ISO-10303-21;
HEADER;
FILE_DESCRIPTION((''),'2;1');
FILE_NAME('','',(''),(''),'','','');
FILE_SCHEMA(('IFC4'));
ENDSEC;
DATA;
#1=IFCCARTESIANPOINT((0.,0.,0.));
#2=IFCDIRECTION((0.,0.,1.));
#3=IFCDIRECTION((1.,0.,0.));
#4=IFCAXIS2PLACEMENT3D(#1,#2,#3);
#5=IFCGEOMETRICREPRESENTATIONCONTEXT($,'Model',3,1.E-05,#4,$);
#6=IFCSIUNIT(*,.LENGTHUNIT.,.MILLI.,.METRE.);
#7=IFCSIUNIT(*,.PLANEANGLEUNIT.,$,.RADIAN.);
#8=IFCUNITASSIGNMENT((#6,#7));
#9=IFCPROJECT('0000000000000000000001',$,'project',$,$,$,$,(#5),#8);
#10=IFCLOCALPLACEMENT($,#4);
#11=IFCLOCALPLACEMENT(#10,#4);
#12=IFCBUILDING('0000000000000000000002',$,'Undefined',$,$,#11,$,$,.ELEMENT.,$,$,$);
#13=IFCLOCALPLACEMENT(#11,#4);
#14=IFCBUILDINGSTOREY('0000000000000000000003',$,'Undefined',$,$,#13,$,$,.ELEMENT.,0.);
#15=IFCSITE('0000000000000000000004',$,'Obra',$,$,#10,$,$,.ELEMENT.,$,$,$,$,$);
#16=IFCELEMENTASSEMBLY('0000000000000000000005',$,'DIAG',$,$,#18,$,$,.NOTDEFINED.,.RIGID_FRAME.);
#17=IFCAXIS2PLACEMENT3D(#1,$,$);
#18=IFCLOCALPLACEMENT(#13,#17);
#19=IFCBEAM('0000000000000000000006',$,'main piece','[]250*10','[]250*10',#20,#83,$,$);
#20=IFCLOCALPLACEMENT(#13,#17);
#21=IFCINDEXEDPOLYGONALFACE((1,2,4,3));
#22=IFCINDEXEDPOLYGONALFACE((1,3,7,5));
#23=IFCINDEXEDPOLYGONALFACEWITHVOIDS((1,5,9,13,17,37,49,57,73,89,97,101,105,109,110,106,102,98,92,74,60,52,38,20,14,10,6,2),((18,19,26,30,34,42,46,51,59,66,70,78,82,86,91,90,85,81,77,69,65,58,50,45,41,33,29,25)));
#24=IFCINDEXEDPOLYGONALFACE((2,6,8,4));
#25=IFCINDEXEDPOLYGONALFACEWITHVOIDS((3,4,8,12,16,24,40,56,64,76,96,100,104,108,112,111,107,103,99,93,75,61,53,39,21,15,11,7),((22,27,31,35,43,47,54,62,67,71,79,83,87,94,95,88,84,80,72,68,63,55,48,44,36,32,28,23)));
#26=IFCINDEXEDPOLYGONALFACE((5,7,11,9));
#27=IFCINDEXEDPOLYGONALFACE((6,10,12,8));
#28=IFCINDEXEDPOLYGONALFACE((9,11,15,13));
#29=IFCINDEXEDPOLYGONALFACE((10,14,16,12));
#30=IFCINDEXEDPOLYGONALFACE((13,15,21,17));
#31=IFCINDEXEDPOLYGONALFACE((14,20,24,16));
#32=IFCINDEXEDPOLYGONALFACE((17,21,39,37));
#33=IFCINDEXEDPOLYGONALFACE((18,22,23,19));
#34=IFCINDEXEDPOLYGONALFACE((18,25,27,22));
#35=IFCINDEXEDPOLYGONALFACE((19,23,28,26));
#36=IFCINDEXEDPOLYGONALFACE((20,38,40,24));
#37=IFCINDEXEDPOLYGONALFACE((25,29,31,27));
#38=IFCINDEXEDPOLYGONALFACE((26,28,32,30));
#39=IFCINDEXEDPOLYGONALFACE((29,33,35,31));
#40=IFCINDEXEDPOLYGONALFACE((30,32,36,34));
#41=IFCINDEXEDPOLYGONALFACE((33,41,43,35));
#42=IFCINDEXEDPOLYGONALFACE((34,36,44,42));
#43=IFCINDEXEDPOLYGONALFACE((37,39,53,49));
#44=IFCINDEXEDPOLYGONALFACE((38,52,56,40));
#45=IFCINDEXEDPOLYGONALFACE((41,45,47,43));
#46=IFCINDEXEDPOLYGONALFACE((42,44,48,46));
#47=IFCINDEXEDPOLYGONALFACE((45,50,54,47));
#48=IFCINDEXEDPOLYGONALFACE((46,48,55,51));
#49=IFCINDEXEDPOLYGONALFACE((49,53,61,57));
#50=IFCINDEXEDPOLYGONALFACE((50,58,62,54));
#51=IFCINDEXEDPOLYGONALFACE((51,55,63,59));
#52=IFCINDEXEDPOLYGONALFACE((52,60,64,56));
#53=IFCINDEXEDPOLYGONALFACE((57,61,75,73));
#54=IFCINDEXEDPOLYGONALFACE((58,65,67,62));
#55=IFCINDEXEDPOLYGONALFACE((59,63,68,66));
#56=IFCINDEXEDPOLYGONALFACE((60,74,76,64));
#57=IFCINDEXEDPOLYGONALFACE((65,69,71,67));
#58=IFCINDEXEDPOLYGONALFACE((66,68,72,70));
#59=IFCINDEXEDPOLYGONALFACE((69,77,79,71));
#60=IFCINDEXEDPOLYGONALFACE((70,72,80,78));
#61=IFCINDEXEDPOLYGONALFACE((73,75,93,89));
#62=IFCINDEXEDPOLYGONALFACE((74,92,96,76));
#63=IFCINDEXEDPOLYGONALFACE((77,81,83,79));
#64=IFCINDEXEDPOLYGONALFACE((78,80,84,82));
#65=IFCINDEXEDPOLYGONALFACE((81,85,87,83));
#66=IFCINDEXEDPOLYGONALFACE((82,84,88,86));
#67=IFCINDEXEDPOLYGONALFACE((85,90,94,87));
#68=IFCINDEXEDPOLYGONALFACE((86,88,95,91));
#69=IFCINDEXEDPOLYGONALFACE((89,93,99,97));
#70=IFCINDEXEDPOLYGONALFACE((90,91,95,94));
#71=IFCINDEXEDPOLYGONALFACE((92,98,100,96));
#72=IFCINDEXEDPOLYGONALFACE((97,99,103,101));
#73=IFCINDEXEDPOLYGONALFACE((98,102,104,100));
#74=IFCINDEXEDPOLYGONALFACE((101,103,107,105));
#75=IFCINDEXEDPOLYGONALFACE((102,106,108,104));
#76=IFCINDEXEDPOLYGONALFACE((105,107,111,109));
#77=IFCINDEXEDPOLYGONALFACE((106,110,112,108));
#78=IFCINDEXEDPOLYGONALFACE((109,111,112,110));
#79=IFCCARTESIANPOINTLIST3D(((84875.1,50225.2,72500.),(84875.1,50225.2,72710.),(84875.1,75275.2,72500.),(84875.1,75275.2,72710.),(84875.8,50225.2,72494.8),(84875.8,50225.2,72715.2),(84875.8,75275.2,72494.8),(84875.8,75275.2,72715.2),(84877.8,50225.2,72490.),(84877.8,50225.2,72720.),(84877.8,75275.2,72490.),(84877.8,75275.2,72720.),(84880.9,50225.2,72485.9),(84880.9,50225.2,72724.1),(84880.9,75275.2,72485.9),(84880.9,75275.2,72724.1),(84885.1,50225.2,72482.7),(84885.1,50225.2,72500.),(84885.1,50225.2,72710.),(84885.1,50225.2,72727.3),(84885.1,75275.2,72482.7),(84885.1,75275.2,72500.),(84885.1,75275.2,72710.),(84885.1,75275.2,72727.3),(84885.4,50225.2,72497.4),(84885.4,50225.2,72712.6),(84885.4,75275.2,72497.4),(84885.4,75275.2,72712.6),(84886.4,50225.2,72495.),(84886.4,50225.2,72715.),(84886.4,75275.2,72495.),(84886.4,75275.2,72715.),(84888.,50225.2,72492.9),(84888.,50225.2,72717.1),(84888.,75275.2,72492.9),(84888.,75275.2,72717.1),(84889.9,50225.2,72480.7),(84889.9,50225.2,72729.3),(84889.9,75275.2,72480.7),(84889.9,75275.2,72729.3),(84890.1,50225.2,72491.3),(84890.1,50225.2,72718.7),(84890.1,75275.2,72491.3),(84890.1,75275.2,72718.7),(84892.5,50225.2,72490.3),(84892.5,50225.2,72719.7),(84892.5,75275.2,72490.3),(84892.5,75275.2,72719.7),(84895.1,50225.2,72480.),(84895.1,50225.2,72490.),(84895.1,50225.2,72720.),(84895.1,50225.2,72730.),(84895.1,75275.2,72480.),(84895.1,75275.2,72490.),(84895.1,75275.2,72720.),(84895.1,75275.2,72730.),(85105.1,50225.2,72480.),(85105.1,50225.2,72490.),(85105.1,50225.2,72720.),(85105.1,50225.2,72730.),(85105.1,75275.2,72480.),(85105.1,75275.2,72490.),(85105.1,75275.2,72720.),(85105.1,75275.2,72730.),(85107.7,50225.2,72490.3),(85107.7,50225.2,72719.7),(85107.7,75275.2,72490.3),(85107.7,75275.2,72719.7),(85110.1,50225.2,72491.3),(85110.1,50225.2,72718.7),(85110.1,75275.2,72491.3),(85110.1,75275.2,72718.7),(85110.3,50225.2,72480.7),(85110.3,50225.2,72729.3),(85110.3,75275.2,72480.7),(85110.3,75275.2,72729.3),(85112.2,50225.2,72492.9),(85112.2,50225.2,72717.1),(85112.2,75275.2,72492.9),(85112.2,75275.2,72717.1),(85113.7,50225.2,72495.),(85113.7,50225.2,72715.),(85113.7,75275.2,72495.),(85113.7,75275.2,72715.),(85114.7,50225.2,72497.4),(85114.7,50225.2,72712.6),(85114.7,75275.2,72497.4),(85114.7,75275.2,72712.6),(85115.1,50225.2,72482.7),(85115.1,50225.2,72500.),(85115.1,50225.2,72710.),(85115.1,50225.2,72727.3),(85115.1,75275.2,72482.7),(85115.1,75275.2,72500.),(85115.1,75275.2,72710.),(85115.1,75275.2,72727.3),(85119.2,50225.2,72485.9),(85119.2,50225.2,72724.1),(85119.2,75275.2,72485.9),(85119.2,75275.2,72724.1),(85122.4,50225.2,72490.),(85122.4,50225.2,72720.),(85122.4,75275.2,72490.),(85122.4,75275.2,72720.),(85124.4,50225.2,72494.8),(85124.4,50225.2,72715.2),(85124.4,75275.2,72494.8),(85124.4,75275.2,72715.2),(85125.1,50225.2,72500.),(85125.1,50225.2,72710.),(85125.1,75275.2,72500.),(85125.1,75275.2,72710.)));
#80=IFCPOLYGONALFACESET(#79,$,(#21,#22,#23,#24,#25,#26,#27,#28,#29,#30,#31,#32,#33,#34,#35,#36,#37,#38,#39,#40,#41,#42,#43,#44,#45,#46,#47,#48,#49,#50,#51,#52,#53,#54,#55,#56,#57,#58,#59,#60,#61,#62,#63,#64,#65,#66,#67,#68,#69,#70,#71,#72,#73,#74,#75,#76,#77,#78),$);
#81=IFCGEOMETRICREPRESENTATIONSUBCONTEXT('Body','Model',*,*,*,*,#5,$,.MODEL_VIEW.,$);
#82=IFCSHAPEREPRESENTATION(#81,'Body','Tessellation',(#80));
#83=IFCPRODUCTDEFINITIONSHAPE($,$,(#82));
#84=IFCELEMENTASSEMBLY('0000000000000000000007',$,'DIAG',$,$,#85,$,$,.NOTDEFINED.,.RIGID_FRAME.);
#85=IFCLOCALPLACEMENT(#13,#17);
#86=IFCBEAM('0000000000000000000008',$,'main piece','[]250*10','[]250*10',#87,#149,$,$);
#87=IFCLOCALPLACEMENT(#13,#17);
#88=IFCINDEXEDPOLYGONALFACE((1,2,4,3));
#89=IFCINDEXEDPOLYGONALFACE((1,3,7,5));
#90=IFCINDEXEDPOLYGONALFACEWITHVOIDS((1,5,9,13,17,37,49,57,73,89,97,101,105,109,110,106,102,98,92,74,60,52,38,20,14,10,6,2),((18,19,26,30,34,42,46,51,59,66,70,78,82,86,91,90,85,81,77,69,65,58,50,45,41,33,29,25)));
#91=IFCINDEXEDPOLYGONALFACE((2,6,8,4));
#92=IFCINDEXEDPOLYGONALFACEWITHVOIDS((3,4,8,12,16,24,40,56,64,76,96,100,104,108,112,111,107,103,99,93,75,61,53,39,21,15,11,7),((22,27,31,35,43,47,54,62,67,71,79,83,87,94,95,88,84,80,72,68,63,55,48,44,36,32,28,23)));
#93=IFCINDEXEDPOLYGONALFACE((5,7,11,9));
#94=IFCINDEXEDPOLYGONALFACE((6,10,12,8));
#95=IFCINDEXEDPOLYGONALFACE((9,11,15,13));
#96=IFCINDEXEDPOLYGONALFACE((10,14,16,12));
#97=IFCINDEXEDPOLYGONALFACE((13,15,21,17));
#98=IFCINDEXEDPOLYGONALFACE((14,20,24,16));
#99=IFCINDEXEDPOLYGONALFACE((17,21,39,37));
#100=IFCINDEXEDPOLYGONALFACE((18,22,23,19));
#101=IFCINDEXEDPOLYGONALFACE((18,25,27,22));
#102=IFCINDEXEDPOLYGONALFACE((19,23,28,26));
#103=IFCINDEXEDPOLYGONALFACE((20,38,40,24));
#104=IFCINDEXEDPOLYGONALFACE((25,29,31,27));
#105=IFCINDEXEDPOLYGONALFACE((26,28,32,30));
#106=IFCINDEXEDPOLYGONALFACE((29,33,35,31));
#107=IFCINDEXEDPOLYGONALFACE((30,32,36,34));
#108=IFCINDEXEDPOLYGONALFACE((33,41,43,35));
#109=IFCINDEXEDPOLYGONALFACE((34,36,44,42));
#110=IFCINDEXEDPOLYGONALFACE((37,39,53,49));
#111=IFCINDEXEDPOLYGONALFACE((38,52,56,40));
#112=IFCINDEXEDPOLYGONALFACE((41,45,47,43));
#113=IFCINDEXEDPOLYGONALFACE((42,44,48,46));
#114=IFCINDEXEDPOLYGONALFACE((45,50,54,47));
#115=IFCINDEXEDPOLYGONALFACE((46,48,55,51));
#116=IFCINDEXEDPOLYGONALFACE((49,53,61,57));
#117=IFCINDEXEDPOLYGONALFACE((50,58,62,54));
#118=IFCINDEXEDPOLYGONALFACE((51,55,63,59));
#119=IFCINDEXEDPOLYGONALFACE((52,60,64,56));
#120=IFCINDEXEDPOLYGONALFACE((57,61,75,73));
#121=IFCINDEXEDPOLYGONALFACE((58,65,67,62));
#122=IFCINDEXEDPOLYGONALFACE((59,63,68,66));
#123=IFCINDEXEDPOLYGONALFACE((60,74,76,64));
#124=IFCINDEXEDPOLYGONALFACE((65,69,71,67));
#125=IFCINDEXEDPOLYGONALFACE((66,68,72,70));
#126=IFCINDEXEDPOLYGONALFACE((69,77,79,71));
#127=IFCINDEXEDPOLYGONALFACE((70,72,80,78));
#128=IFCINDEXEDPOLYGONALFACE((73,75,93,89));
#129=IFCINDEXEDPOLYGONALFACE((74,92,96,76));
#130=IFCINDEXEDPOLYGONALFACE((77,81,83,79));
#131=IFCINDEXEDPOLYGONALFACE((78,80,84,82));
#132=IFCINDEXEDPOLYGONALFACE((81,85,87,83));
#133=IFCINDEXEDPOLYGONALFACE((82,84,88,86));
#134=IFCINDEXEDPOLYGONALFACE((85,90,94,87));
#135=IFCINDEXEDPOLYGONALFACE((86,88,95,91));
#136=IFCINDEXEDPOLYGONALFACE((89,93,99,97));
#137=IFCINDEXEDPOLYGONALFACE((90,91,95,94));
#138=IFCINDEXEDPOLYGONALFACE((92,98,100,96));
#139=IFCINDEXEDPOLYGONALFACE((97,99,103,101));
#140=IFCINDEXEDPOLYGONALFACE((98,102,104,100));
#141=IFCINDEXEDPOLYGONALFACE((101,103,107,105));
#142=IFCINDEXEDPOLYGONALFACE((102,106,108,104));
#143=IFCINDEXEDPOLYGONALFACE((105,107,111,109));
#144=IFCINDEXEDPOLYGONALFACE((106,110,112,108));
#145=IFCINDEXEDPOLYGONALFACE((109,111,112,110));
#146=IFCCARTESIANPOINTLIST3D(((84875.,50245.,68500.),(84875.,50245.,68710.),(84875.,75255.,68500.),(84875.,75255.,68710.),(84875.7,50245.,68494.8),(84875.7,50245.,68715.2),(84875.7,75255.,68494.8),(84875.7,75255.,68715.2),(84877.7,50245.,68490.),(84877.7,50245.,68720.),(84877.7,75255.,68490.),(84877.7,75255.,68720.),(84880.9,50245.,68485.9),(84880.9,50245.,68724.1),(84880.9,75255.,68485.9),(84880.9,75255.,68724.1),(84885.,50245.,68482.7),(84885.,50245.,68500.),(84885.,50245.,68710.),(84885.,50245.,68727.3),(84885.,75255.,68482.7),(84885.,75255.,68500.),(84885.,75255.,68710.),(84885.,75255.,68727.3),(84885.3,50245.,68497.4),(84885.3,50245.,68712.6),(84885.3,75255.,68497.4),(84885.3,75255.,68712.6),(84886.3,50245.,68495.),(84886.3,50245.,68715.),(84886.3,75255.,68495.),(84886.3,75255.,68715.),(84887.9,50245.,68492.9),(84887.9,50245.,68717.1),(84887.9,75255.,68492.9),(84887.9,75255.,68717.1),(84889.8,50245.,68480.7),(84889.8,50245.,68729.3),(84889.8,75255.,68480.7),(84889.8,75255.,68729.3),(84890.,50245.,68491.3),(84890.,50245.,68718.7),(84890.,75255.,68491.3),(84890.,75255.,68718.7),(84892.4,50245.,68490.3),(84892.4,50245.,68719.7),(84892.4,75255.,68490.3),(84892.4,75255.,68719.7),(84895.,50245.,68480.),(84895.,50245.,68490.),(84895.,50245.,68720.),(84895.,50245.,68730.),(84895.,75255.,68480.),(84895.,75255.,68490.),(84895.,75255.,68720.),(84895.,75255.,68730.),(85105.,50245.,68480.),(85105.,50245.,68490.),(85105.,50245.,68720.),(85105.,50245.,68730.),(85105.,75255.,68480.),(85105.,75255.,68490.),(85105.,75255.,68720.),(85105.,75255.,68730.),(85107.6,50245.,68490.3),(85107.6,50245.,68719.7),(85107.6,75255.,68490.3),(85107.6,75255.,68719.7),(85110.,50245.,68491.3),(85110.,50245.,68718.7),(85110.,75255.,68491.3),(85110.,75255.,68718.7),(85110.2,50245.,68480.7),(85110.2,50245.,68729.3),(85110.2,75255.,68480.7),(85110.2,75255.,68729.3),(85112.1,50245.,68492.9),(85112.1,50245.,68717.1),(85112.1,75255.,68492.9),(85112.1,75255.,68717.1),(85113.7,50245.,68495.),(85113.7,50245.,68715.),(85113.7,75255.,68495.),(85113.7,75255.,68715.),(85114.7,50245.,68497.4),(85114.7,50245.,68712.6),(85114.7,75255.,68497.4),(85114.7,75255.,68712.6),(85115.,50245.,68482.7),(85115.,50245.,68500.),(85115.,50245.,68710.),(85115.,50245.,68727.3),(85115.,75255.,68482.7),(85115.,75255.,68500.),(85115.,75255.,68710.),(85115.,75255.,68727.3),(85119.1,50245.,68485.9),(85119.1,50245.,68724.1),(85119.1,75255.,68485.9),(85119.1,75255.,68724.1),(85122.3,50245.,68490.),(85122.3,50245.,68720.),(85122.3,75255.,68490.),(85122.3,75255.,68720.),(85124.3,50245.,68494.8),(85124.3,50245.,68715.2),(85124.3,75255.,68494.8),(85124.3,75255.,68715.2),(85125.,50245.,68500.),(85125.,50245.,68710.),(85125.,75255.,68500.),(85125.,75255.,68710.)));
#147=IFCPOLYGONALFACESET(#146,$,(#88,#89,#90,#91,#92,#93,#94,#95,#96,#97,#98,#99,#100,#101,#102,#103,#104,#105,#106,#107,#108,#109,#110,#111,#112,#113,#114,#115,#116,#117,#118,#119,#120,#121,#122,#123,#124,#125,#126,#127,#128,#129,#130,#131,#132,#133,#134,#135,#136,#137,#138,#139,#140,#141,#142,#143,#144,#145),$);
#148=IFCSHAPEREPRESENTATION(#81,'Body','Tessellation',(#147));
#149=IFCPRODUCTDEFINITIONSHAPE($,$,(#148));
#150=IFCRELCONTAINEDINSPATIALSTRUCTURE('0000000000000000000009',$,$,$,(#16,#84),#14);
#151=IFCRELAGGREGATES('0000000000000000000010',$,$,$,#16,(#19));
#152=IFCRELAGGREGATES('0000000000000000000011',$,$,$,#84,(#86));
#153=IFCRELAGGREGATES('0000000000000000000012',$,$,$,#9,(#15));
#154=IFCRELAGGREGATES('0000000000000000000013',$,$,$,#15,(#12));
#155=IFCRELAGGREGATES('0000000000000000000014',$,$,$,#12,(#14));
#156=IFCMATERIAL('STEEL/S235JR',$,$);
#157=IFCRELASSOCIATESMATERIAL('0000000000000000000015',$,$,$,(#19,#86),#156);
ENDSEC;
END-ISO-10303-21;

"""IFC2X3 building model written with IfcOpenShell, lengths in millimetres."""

from ifc_helpers import new_model, si_unit, frame, origin_with_axes, origin_2d_with_axis, place, context, subcontext, project, spatial, hollow_rectangle, extrude, material, element, aggregate, save


model = new_model("IFC2X3")

# Units and contexts
model_context = context("Model", 3, precision=1e-05, world=origin_with_axes())
body_context = subcontext(model_context, "Body", "Model", "MODEL_VIEW")
ifc_project = project(units=[si_unit("LENGTHUNIT", "METRE", prefix="MILLI"), si_unit("PLANEANGLEUNIT", "RADIAN")], contexts=[model_context])

# Site, building, storey
site_placement = place(None, origin_with_axes())
site = spatial("IfcSite", under=ifc_project, at=site_placement, Name="Obra", CompositionType="ELEMENT")
building_placement = place(site_placement, origin_with_axes())
building = spatial("IfcBuilding", under=site, at=building_placement, Name="Undefined", CompositionType="ELEMENT")
storey_placement = place(building_placement, origin_with_axes())
storey = spatial("IfcBuildingStorey", under=building, at=storey_placement, Name="Undefined", CompositionType="ELEMENT", Elevation=0.0)

# Shared definitions
ifc_material = material(Name="STEEL/S235JR")

# Element assemblies, beams
assembly_1_placement = place(storey_placement, origin_with_axes())
assembly_1 = element("IfcElementAssembly", 1, at=assembly_1_placement, inside=storey, Name="DIAG", AssemblyPlace="NOTDEFINED", PredefinedType="RIGID_FRAME")
beam_1_placement = place(assembly_1_placement, frame((85000.1, 50225.2, 72605.0), z_axis=(0.0, 0.0, 1.0), x_axis=(0.0, 1.0, 0.0)))
beam_1 = element("IfcBeam", 2, at=beam_1_placement, material=ifc_material, Name="main piece", Description="[]250*10", ObjectType="[]250*10", context=body_context, shape_type="SweptSolid", body=[
    extrude(hollow_rectangle(XDim=250.0, YDim=250.0, WallThickness=10.0, InnerFilletRadius=10.0, OuterFilletRadius=20.0, at=origin_2d_with_axis()), frame((25050.0, 0.0, 0.0), z_axis=(-1.0, 0.0, 0.0), x_axis=(0.0, -1.0, 0.0)), (0.0, 0.0, 1.0), 25050.0),
])
aggregate(assembly_1, [beam_1])
assembly_2_placement = place(storey_placement, origin_with_axes())
assembly_2 = element("IfcElementAssembly", 3, at=assembly_2_placement, inside=storey, Name="DIAG", AssemblyPlace="NOTDEFINED", PredefinedType="RIGID_FRAME")
beam_2_placement = place(assembly_2_placement, frame((85000.0, 50245.0, 68605.0), z_axis=(0.0, 0.0, 1.0), x_axis=(0.0, 1.0, 0.0)))
beam_2 = element("IfcBeam", 4, at=beam_2_placement, material=ifc_material, Name="main piece", Description="[]250*10", ObjectType="[]250*10", context=body_context, shape_type="SweptSolid", body=[
    extrude(hollow_rectangle(XDim=250.0, YDim=250.0, WallThickness=10.0, InnerFilletRadius=10.0, OuterFilletRadius=20.0, at=origin_2d_with_axis()), frame((25010.0, 0.0, 0.0), z_axis=(-1.0, 0.0, 0.0), x_axis=(0.0, -1.0, 0.0)), (0.0, 0.0, 1.0), 25010.0),
])
aggregate(assembly_2, [beam_2])

save(model, "model.ifc")
